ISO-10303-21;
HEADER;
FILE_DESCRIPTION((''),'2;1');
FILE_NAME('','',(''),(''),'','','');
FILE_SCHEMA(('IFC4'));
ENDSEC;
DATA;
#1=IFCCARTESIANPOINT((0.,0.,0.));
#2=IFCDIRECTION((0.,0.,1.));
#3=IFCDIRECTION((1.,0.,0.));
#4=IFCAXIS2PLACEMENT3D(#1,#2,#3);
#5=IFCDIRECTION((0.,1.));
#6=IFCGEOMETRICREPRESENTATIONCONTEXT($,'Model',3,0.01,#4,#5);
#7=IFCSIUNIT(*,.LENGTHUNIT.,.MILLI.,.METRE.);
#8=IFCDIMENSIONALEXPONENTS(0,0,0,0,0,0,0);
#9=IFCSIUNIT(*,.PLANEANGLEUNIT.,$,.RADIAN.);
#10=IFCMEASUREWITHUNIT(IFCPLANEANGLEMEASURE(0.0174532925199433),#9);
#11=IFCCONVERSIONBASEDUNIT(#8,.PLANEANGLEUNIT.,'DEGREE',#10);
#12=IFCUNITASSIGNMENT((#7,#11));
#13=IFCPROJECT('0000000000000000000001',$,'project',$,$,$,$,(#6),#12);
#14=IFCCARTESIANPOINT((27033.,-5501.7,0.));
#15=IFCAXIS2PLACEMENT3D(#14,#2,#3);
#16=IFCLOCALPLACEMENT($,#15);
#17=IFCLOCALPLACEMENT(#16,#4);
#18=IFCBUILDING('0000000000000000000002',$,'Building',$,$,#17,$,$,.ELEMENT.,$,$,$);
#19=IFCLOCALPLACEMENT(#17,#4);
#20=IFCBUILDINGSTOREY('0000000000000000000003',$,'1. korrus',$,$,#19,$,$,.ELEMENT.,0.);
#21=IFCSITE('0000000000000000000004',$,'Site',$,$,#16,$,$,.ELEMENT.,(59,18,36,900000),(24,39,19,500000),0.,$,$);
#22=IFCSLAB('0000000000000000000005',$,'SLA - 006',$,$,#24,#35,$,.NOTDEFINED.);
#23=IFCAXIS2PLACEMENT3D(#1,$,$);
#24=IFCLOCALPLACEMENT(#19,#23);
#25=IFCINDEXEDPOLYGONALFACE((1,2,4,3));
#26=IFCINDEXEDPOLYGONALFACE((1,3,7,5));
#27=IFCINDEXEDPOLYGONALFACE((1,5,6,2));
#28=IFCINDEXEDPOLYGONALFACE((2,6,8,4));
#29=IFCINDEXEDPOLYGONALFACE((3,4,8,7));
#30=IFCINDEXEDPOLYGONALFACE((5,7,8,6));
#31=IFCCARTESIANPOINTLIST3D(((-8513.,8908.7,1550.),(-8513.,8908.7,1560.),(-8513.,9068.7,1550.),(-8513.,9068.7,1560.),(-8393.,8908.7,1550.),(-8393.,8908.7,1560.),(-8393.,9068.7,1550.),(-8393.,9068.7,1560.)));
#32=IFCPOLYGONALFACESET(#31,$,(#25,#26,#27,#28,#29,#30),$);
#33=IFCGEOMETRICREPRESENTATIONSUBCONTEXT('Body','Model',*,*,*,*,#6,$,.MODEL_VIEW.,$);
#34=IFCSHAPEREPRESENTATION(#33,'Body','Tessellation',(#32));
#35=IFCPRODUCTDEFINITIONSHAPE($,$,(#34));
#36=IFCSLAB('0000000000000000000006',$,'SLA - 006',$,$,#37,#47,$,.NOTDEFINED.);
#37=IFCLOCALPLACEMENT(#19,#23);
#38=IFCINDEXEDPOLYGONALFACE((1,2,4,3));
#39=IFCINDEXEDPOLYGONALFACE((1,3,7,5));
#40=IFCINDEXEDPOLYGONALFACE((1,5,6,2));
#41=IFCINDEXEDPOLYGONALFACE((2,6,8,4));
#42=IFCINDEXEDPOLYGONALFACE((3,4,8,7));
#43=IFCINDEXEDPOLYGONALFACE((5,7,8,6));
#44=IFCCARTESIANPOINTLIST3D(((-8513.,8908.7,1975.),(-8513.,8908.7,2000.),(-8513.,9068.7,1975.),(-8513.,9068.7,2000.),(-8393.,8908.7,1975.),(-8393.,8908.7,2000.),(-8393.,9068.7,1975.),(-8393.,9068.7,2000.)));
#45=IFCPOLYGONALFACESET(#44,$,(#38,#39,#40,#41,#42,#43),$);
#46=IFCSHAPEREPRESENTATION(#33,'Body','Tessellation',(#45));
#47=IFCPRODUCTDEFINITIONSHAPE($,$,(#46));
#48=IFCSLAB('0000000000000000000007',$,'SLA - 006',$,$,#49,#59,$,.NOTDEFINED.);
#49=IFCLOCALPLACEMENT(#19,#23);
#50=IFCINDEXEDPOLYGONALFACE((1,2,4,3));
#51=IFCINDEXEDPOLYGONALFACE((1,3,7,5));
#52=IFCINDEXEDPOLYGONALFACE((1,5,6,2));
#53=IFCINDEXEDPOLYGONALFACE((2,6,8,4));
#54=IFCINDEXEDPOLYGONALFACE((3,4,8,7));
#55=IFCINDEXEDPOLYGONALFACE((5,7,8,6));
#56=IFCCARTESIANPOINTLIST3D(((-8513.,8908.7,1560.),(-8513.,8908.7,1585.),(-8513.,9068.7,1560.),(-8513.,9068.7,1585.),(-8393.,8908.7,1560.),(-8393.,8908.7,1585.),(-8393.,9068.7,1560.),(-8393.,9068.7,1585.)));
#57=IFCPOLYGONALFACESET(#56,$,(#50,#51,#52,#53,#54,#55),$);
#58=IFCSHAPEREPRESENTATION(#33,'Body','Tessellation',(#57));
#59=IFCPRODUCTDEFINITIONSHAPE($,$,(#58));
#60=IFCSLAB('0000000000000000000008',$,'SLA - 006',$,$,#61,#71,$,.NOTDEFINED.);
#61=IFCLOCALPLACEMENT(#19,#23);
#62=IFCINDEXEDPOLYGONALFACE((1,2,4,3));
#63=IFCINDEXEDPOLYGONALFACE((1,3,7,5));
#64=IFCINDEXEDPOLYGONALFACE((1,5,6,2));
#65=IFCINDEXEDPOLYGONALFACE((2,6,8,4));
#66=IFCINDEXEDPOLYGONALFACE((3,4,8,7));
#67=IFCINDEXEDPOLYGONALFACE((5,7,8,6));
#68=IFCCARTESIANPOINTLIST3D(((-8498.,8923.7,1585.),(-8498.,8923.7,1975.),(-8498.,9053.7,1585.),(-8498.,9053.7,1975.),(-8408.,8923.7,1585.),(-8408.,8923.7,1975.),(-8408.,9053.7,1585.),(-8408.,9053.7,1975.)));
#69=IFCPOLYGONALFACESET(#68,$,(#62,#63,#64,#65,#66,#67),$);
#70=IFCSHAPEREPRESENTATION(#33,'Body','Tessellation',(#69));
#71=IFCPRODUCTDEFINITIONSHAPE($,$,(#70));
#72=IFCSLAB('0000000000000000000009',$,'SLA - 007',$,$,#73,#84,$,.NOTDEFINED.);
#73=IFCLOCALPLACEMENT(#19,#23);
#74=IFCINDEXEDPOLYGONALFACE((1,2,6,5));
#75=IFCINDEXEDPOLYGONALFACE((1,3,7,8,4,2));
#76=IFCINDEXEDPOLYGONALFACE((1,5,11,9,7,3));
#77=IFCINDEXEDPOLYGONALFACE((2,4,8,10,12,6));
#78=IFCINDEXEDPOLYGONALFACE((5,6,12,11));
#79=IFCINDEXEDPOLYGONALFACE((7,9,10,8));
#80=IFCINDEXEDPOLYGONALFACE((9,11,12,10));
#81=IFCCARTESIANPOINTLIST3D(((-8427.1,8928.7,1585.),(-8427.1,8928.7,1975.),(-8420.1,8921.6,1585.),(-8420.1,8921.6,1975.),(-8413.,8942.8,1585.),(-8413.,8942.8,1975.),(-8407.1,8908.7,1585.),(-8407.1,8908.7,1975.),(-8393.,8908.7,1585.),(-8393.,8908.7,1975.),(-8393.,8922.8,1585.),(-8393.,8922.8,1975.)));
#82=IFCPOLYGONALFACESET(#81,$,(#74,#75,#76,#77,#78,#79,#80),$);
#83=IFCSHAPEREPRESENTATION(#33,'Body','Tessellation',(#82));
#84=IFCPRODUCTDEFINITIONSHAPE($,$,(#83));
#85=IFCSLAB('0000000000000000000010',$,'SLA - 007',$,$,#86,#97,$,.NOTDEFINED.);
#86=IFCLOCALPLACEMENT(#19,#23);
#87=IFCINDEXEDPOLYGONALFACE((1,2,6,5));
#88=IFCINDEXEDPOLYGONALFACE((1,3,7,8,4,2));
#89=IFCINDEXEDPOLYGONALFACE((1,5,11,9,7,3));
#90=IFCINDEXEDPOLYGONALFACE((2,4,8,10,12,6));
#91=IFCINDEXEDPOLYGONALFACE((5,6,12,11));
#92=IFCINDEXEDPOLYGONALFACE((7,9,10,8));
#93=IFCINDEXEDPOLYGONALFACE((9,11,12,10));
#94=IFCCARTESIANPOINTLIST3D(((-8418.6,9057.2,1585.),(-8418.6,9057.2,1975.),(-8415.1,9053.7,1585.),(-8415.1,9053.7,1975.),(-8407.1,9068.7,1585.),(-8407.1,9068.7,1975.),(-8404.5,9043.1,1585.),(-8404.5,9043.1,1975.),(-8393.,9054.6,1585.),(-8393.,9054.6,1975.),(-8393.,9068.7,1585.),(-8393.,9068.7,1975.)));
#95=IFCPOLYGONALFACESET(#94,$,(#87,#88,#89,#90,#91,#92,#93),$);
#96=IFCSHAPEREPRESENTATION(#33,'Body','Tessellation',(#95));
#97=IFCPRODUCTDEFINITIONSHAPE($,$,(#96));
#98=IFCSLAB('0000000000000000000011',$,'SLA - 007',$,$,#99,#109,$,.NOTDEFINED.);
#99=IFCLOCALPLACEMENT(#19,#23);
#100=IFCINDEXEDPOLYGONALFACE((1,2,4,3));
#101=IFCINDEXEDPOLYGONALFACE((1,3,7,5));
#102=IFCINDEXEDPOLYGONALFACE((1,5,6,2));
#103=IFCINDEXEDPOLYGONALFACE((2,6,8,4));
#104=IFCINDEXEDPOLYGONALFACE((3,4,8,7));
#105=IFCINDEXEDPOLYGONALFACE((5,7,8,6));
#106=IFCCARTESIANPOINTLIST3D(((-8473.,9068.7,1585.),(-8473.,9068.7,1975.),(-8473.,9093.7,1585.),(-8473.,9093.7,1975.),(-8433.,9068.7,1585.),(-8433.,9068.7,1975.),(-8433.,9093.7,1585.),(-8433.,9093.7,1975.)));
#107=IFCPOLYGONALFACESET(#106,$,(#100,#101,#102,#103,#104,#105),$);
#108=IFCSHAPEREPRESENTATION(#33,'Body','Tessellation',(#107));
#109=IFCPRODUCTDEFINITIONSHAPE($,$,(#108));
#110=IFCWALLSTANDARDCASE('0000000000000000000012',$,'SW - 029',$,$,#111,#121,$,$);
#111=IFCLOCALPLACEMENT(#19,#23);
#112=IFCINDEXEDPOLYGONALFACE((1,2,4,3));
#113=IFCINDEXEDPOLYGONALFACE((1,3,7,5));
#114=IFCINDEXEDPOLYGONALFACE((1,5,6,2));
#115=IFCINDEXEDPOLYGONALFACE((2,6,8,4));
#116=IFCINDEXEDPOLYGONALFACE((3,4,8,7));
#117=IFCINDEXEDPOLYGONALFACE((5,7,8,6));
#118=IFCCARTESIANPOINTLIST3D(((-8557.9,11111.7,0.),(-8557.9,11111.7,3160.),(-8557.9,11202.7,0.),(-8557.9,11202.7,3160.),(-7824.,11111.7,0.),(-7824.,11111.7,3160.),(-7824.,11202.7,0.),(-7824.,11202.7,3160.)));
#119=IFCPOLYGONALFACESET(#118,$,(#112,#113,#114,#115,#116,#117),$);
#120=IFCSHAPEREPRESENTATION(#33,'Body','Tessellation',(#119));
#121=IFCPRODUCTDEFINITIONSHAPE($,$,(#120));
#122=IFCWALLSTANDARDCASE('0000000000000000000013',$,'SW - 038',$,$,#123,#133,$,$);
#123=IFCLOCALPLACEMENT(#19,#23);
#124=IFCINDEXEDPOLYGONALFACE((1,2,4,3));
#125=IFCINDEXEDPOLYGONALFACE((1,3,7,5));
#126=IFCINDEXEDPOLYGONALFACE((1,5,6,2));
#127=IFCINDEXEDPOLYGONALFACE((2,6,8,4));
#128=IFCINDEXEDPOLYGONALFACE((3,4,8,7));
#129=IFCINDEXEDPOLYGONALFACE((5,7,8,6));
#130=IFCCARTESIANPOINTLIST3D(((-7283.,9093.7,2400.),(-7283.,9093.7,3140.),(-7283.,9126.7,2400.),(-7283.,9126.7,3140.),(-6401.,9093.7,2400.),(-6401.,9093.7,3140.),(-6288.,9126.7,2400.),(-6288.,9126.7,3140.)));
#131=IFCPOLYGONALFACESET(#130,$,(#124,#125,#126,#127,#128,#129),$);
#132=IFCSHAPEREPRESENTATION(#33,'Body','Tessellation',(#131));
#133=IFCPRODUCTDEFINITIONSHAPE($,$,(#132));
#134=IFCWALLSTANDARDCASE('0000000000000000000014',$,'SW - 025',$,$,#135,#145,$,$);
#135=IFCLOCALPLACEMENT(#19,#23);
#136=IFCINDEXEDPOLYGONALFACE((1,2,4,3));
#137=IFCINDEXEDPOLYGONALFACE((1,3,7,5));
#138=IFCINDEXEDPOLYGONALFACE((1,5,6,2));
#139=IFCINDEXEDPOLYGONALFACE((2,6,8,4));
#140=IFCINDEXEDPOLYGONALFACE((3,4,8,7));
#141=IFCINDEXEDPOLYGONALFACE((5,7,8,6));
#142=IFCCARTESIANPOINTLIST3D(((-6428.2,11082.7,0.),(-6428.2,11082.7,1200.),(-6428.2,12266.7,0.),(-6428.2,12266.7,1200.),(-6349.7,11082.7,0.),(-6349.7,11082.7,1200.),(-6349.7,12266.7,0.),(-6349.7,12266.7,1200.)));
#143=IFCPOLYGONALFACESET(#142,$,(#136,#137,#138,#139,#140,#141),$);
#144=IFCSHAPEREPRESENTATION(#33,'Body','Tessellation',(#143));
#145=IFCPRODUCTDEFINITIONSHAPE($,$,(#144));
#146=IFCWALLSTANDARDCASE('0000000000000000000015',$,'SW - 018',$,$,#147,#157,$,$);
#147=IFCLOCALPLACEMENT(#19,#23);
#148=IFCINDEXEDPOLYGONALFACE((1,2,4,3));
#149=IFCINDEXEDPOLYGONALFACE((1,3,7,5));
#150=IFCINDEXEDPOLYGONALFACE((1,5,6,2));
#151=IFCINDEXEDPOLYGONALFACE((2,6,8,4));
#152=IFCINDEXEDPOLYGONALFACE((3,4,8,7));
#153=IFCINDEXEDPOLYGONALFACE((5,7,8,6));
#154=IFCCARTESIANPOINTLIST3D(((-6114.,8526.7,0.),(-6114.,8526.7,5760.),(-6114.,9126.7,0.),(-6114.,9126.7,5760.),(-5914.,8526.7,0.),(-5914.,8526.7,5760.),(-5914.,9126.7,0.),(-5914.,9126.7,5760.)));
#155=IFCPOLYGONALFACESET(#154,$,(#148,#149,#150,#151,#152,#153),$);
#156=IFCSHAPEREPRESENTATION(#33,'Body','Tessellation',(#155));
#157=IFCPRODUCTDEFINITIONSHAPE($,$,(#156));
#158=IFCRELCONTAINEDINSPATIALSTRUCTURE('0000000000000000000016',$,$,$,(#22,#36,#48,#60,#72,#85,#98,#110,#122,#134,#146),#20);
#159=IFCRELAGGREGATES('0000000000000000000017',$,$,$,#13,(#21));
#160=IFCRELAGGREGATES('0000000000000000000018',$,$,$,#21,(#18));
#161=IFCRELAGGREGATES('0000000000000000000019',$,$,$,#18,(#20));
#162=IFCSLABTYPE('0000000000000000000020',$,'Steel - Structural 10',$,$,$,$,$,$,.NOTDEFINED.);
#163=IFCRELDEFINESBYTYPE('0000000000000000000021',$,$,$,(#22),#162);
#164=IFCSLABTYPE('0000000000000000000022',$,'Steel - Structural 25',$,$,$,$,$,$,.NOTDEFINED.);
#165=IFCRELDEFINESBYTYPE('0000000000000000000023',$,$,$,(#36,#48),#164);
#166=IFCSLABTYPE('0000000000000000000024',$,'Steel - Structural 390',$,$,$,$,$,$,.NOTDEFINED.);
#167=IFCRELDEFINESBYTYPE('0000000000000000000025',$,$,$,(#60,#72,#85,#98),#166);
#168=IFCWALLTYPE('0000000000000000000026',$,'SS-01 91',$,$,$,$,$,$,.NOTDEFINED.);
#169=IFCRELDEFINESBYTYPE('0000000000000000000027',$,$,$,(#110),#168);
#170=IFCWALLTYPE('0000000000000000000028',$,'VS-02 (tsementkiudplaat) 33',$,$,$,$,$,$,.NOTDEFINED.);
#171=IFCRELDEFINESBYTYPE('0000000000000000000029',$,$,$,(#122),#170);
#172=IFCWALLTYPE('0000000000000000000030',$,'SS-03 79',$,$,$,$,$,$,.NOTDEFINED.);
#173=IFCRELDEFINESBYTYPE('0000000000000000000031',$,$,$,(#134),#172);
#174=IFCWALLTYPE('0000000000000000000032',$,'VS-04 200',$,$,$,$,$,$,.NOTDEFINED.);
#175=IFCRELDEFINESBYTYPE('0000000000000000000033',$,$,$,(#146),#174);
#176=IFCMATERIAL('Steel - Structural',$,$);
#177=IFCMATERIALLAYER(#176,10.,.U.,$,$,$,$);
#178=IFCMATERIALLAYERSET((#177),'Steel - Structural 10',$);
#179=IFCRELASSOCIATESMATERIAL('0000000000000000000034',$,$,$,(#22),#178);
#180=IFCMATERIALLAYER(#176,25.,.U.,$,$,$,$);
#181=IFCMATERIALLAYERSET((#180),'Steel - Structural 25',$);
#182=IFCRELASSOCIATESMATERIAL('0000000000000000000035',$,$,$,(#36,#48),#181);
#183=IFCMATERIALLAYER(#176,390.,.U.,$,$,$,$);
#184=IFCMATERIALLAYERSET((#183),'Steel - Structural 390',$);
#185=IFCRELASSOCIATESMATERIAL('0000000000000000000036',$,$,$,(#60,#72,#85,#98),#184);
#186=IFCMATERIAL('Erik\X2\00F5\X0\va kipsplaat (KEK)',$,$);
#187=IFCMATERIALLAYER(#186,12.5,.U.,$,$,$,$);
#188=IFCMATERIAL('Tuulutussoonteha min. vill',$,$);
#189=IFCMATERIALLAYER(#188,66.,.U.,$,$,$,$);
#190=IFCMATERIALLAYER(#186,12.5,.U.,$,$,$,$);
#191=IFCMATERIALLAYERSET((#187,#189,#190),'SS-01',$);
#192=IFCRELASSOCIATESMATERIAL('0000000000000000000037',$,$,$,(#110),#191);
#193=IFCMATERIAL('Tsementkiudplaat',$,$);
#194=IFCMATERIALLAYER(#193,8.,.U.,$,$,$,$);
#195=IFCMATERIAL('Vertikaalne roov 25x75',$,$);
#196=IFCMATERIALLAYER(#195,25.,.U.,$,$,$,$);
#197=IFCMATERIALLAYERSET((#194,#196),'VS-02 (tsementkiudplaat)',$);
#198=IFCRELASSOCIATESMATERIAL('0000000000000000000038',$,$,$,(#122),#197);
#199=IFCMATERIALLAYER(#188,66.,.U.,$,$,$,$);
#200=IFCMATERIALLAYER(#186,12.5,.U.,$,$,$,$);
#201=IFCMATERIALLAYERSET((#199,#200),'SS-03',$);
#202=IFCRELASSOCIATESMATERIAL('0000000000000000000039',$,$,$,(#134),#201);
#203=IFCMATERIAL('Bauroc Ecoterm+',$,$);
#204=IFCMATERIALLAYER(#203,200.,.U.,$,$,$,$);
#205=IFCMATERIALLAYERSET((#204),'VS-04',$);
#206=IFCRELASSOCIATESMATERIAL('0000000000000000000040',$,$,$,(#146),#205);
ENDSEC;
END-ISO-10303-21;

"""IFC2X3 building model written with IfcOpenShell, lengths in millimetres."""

from ifc_helpers import new_model, entity, si_unit, converted_unit, direction, frame, origin_with_axes, origin_2d_with_axis, place, context, subcontext, project, spatial, polyline, rectangle, outline, extrude, material, layer, layer_set, layer_usage, type_object, element, save


model = new_model("IFC2X3")

# Units and contexts
model_context = context("Model", 3, precision=0.01, world=origin_with_axes(), true_north=direction((0.0, 1.0)))
body_context = subcontext(model_context, "Body", "Model", "MODEL_VIEW")
ifc_project = project(units=[si_unit("LENGTHUNIT", "METRE", prefix="MILLI"), converted_unit("PLANEANGLEUNIT", "DEGREE", entity("IfcPlaneAngleMeasure", 0.0174532925199433), si_unit("PLANEANGLEUNIT", "RADIAN"), dimensions=[0, 0, 0, 0, 0, 0, 0])], contexts=[model_context])

# Site, building, storey
site_placement = place(None, frame((27033.0, -5501.7, 0.0), z_axis=(0.0, 0.0, 1.0), x_axis=(1.0, 0.0, 0.0)))
site = spatial("IfcSite", under=ifc_project, at=site_placement, Name="Site", CompositionType="ELEMENT", RefLatitude=(59, 18, 36, 900000), RefLongitude=(24, 39, 19, 500000), RefElevation=0.0)
building_placement = place(site_placement, origin_with_axes())
building = spatial("IfcBuilding", under=site, at=building_placement, Name="Building", CompositionType="ELEMENT")
storey_placement = place(building_placement, origin_with_axes())
storey = spatial("IfcBuildingStorey", under=building, at=storey_placement, Name="1. korrus", CompositionType="ELEMENT", Elevation=0.0)

# Slabs
ifc_material_1 = material(Name="Steel - Structural")
ifc_layer_1 = layer(ifc_material_1, 10.0, ventilated="UNKNOWN")
ifc_layer_set_1 = layer_set([ifc_layer_1], Name="Steel - Structural 10")
ifc_layer_usage_1 = layer_usage(ifc_layer_set_1, "AXIS3", "NEGATIVE", 10.0)
slab_type_1 = type_object("IfcSlabType", Name="Steel - Structural 10", PredefinedType="NOTDEFINED")
slab_1_placement = place(storey_placement, frame((-8393.0, 9068.7, 1550.0), z_axis=(0.0, 0.0, 1.0), x_axis=(1.0, 0.0, 0.0)))
element("IfcSlab", 1, at=slab_1_placement, inside=storey, type_object=slab_type_1, material=ifc_layer_usage_1, Name="SLA - 006", PredefinedType="NOTDEFINED", context=body_context, shape_type="SweptSolid", body=[
    extrude(outline(polyline([(0.0, 0.0), (-120.0, 0.0), (-120.0, -160.0), (0.0, -160.0), (0.0, 0.0)])), origin_with_axes(), (0.0, 0.0, 1.0), 10.0),
])
ifc_layer_2 = layer(ifc_material_1, 25.0, ventilated="UNKNOWN")
ifc_layer_set_2 = layer_set([ifc_layer_2], Name="Steel - Structural 25")
ifc_layer_usage_2 = layer_usage(ifc_layer_set_2, "AXIS3", "NEGATIVE", 25.0)
slab_type_2 = type_object("IfcSlabType", Name="Steel - Structural 25", PredefinedType="NOTDEFINED")
slab_2_placement = place(storey_placement, frame((-8393.0, 9068.7, 2000.0), z_axis=(0.0, 0.0, 1.0), x_axis=(1.0, 0.0, 0.0)))
element("IfcSlab", 2, at=slab_2_placement, inside=storey, type_object=slab_type_2, material=ifc_layer_usage_2, Name="SLA - 006", PredefinedType="NOTDEFINED", context=body_context, shape_type="SweptSolid", body=[
    extrude(outline(polyline([(0.0, 0.0), (-120.0, 0.0), (-120.0, -160.0), (0.0, -160.0), (0.0, 0.0)])), frame((0.0, 0.0, -25.0), z_axis=(0.0, 0.0, 1.0), x_axis=(1.0, 0.0, 0.0)), (0.0, 0.0, 1.0), 25.0),
])
ifc_layer_usage_3 = layer_usage(ifc_layer_set_2, "AXIS3", "NEGATIVE", 25.0)
slab_3_placement = place(storey_placement, frame((-8393.0, 9068.7, 1560.0), z_axis=(0.0, 0.0, 1.0), x_axis=(1.0, 0.0, 0.0)))
element("IfcSlab", 3, at=slab_3_placement, inside=storey, type_object=slab_type_2, material=ifc_layer_usage_3, Name="SLA - 006", PredefinedType="NOTDEFINED", context=body_context, shape_type="SweptSolid", body=[
    extrude(outline(polyline([(0.0, 0.0), (-120.0, 0.0), (-120.0, -160.0), (0.0, -160.0), (0.0, 0.0)])), origin_with_axes(), (0.0, 0.0, 1.0), 25.0),
])
ifc_layer_3 = layer(ifc_material_1, 390.0, ventilated="UNKNOWN")
ifc_layer_set_3 = layer_set([ifc_layer_3], Name="Steel - Structural 390")
ifc_layer_usage_4 = layer_usage(ifc_layer_set_3, "AXIS3", "NEGATIVE", 390.0)
slab_type_3 = type_object("IfcSlabType", Name="Steel - Structural 390", PredefinedType="NOTDEFINED")
slab_4_placement = place(storey_placement, frame((-8408.0, 9053.7, 1585.0), z_axis=(0.0, 0.0, 1.0), x_axis=(1.0, 0.0, 0.0)))
element("IfcSlab", 4, at=slab_4_placement, inside=storey, type_object=slab_type_3, material=ifc_layer_usage_4, Name="SLA - 006", PredefinedType="NOTDEFINED", context=body_context, shape_type="SweptSolid", body=[
    extrude(outline(polyline([(0.0, 0.0), (-90.0, 0.0), (-90.0, -130.0), (0.0, -130.0), (0.0, 0.0)])), origin_with_axes(), (0.0, 0.0, 1.0), 390.0),
])
ifc_layer_usage_5 = layer_usage(ifc_layer_set_3, "AXIS3", "NEGATIVE", 390.0)
slab_5_placement = place(storey_placement, frame((-8420.1, 8921.6, 1585.0), z_axis=(0.0, 0.0, 1.0), x_axis=(1.0, 0.0, 0.0)))
element("IfcSlab", 5, at=slab_5_placement, inside=storey, type_object=slab_type_3, material=ifc_layer_usage_5, Name="SLA - 007", PredefinedType="NOTDEFINED", context=body_context, shape_type="SweptSolid", body=[
    extrude(outline(polyline([(0.0, 0.0), (12.9, -12.9), (27.1, -12.9), (27.1, 1.2), (7.1, 21.2), (-7.1, 7.1), (0.0, 0.0)])), origin_with_axes(), (0.0, 0.0, 1.0), 390.0),
])
ifc_layer_usage_6 = layer_usage(ifc_layer_set_3, "AXIS3", "NEGATIVE", 390.0)
slab_6_placement = place(storey_placement, frame((-8407.1, 9068.7, 1585.0), z_axis=(0.0, 0.0, 1.0), x_axis=(1.0, 0.0, 0.0)))
element("IfcSlab", 6, at=slab_6_placement, inside=storey, type_object=slab_type_3, material=ifc_layer_usage_6, Name="SLA - 007", PredefinedType="NOTDEFINED", context=body_context, shape_type="SweptSolid", body=[
    extrude(outline(polyline([(0.0, 0.0), (-11.5, -11.5), (-7.9, -15.0), (2.7, -25.6), (14.1, -14.1), (14.1, 0.0), (0.0, 0.0)])), origin_with_axes(), (0.0, 0.0, 1.0), 390.0),
])
ifc_layer_usage_7 = layer_usage(ifc_layer_set_3, "AXIS3", "NEGATIVE", 390.0)
slab_7_placement = place(storey_placement, frame((-8473.0, 9068.7, 1585.0), z_axis=(0.0, 0.0, 1.0), x_axis=(1.0, 0.0, 0.0)))
element("IfcSlab", 7, at=slab_7_placement, inside=storey, type_object=slab_type_3, material=ifc_layer_usage_7, Name="SLA - 007", PredefinedType="NOTDEFINED", context=body_context, shape_type="SweptSolid", body=[
    extrude(outline(polyline([(0.0, 0.0), (40.0, 0.0), (40.0, 25.0), (0.0, 25.0), (0.0, 0.0)])), origin_with_axes(), (0.0, 0.0, 1.0), 390.0),
])

# Shared definitions
ifc_material_2 = material(Name="Bauroc Ecoterm+")

# Shared definitions
ifc_material_3 = material(Name="Erikõva kipsplaat (KEK)")
ifc_layer_4 = layer(ifc_material_3, 12.5, ventilated="UNKNOWN")
ifc_material_4 = material(Name="Tuulutussoonteha min. vill")
ifc_layer_5 = layer(ifc_material_4, 66.0, ventilated="UNKNOWN")
ifc_layer_6 = layer(ifc_material_3, 12.5, ventilated="UNKNOWN")
ifc_layer_set_4 = layer_set([ifc_layer_4, ifc_layer_5, ifc_layer_6], Name="SS-01")
wall_type_1 = type_object("IfcWallType", Name="SS-01 91", PredefinedType="NOTDEFINED")

# Wall
ifc_layer_usage_8 = layer_usage(ifc_layer_set_4, "AXIS2", "POSITIVE", -91.0)
wall_1_placement = place(storey_placement, frame((-7824.0, 11111.7, 0.0), z_axis=(0.0, 0.0, 1.0), x_axis=(-1.0, 0.0, 0.0)))
element("IfcWallStandardCase", 8, at=wall_1_placement, inside=storey, type_object=wall_type_1, material=ifc_layer_usage_8, Name="SW - 029", context=body_context, shape_type="SweptSolid", body=[
    extrude(outline(polyline([(0.0, -91.0), (733.9, -91.0), (733.9, 0.0), (0.0, 0.0), (0.0, -91.0)])), origin_with_axes(), (0.0, 0.0, 1.0), 3160.0),
])

# Wall, opening
ifc_material_5 = material(Name="Tsementkiudplaat")
ifc_layer_7 = layer(ifc_material_5, 8.0, ventilated="UNKNOWN")
ifc_material_6 = material(Name="Vertikaalne roov 25x75")
ifc_layer_8 = layer(ifc_material_6, 25.0, ventilated="UNKNOWN")
ifc_layer_set_5 = layer_set([ifc_layer_7, ifc_layer_8], Name="VS-02 (tsementkiudplaat)")
ifc_layer_usage_9 = layer_usage(ifc_layer_set_5, "AXIS2", "POSITIVE", -33.0)
wall_type_2 = type_object("IfcWallType", Name="VS-02 (tsementkiudplaat) 33", PredefinedType="NOTDEFINED")
wall_2_placement = place(storey_placement, frame((-7283.0, 9126.7, 2400.0), z_axis=(0.0, 0.0, 1.0), x_axis=(1.0, 0.0, 0.0)))
wall_2 = element("IfcWallStandardCase", 9, at=wall_2_placement, inside=storey, type_object=wall_type_2, material=ifc_layer_usage_9, Name="SW - 038", context=body_context, shape_type="SweptSolid", body=[
    extrude(outline(polyline([(0.0, -33.0), (882.0, -33.0), (995.0, 0.0), (0.0, 0.0), (0.0, -33.0)])), origin_with_axes(), (0.0, 0.0, 1.0), 740.0),
])
opening_1_placement = place(wall_2_placement, frame((441.0, 0.0, -2400.0), z_axis=(0.0, 0.0, 1.0), x_axis=(1.0, 0.0, 0.0)))
element("IfcOpeningElement", 10, at=opening_1_placement, cuts=wall_2, context=body_context, shape_type="SweptSolid", body=[
    extrude(rectangle(XDim=882.0, YDim=2400.0, at=origin_2d_with_axis()), frame((0.0, 33.0, 1200.0), z_axis=(0.0, 1.0, 0.0), x_axis=(-1.0, 0.0, 0.0)), (0.0, 0.0, -1.0), 99.0),
])

# Walls
ifc_layer_9 = layer(ifc_material_4, 66.0, ventilated="UNKNOWN")
ifc_layer_10 = layer(ifc_material_3, 12.5, ventilated="UNKNOWN")
ifc_layer_set_6 = layer_set([ifc_layer_9, ifc_layer_10], Name="SS-03")
ifc_layer_usage_10 = layer_usage(ifc_layer_set_6, "AXIS2", "POSITIVE", -78.5)
wall_type_3 = type_object("IfcWallType", Name="SS-03 79", PredefinedType="NOTDEFINED")
wall_3_placement = place(storey_placement, frame((-6428.2, 11082.7, 0.0), z_axis=(0.0, 0.0, 1.0), x_axis=(0.0, 1.0, 0.0)))
element("IfcWallStandardCase", 11, at=wall_3_placement, inside=storey, type_object=wall_type_3, material=ifc_layer_usage_10, Name="SW - 025", context=body_context, shape_type="SweptSolid", body=[
    extrude(outline(polyline([(0.0, -78.5), (1184.0, -78.5), (1184.0, 0.0), (0.0, 0.0), (0.0, -78.5)])), origin_with_axes(), (0.0, 0.0, 1.0), 1200.0),
])
ifc_layer_11 = layer(ifc_material_2, 200.0, ventilated="UNKNOWN")
ifc_layer_set_7 = layer_set([ifc_layer_11], Name="VS-04")
ifc_layer_usage_11 = layer_usage(ifc_layer_set_7, "AXIS2", "POSITIVE", 0.0)
wall_type_4 = type_object("IfcWallType", Name="VS-04 200", PredefinedType="NOTDEFINED")
wall_4_placement = place(storey_placement, frame((-6114.0, 9126.7, 0.0), z_axis=(0.0, 0.0, 1.0), x_axis=(0.0, -1.0, 0.0)))
element("IfcWallStandardCase", 12, at=wall_4_placement, inside=storey, type_object=wall_type_4, material=ifc_layer_usage_11, Name="SW - 018", context=body_context, shape_type="SweptSolid", body=[
    extrude(outline(polyline([(0.0, 0.0), (600.0, 0.0), (600.0, 200.0), (0.0, 200.0), (0.0, 0.0)])), origin_with_axes(), (0.0, 0.0, 1.0), 5760.0),
])

save(model, "model.ifc")
